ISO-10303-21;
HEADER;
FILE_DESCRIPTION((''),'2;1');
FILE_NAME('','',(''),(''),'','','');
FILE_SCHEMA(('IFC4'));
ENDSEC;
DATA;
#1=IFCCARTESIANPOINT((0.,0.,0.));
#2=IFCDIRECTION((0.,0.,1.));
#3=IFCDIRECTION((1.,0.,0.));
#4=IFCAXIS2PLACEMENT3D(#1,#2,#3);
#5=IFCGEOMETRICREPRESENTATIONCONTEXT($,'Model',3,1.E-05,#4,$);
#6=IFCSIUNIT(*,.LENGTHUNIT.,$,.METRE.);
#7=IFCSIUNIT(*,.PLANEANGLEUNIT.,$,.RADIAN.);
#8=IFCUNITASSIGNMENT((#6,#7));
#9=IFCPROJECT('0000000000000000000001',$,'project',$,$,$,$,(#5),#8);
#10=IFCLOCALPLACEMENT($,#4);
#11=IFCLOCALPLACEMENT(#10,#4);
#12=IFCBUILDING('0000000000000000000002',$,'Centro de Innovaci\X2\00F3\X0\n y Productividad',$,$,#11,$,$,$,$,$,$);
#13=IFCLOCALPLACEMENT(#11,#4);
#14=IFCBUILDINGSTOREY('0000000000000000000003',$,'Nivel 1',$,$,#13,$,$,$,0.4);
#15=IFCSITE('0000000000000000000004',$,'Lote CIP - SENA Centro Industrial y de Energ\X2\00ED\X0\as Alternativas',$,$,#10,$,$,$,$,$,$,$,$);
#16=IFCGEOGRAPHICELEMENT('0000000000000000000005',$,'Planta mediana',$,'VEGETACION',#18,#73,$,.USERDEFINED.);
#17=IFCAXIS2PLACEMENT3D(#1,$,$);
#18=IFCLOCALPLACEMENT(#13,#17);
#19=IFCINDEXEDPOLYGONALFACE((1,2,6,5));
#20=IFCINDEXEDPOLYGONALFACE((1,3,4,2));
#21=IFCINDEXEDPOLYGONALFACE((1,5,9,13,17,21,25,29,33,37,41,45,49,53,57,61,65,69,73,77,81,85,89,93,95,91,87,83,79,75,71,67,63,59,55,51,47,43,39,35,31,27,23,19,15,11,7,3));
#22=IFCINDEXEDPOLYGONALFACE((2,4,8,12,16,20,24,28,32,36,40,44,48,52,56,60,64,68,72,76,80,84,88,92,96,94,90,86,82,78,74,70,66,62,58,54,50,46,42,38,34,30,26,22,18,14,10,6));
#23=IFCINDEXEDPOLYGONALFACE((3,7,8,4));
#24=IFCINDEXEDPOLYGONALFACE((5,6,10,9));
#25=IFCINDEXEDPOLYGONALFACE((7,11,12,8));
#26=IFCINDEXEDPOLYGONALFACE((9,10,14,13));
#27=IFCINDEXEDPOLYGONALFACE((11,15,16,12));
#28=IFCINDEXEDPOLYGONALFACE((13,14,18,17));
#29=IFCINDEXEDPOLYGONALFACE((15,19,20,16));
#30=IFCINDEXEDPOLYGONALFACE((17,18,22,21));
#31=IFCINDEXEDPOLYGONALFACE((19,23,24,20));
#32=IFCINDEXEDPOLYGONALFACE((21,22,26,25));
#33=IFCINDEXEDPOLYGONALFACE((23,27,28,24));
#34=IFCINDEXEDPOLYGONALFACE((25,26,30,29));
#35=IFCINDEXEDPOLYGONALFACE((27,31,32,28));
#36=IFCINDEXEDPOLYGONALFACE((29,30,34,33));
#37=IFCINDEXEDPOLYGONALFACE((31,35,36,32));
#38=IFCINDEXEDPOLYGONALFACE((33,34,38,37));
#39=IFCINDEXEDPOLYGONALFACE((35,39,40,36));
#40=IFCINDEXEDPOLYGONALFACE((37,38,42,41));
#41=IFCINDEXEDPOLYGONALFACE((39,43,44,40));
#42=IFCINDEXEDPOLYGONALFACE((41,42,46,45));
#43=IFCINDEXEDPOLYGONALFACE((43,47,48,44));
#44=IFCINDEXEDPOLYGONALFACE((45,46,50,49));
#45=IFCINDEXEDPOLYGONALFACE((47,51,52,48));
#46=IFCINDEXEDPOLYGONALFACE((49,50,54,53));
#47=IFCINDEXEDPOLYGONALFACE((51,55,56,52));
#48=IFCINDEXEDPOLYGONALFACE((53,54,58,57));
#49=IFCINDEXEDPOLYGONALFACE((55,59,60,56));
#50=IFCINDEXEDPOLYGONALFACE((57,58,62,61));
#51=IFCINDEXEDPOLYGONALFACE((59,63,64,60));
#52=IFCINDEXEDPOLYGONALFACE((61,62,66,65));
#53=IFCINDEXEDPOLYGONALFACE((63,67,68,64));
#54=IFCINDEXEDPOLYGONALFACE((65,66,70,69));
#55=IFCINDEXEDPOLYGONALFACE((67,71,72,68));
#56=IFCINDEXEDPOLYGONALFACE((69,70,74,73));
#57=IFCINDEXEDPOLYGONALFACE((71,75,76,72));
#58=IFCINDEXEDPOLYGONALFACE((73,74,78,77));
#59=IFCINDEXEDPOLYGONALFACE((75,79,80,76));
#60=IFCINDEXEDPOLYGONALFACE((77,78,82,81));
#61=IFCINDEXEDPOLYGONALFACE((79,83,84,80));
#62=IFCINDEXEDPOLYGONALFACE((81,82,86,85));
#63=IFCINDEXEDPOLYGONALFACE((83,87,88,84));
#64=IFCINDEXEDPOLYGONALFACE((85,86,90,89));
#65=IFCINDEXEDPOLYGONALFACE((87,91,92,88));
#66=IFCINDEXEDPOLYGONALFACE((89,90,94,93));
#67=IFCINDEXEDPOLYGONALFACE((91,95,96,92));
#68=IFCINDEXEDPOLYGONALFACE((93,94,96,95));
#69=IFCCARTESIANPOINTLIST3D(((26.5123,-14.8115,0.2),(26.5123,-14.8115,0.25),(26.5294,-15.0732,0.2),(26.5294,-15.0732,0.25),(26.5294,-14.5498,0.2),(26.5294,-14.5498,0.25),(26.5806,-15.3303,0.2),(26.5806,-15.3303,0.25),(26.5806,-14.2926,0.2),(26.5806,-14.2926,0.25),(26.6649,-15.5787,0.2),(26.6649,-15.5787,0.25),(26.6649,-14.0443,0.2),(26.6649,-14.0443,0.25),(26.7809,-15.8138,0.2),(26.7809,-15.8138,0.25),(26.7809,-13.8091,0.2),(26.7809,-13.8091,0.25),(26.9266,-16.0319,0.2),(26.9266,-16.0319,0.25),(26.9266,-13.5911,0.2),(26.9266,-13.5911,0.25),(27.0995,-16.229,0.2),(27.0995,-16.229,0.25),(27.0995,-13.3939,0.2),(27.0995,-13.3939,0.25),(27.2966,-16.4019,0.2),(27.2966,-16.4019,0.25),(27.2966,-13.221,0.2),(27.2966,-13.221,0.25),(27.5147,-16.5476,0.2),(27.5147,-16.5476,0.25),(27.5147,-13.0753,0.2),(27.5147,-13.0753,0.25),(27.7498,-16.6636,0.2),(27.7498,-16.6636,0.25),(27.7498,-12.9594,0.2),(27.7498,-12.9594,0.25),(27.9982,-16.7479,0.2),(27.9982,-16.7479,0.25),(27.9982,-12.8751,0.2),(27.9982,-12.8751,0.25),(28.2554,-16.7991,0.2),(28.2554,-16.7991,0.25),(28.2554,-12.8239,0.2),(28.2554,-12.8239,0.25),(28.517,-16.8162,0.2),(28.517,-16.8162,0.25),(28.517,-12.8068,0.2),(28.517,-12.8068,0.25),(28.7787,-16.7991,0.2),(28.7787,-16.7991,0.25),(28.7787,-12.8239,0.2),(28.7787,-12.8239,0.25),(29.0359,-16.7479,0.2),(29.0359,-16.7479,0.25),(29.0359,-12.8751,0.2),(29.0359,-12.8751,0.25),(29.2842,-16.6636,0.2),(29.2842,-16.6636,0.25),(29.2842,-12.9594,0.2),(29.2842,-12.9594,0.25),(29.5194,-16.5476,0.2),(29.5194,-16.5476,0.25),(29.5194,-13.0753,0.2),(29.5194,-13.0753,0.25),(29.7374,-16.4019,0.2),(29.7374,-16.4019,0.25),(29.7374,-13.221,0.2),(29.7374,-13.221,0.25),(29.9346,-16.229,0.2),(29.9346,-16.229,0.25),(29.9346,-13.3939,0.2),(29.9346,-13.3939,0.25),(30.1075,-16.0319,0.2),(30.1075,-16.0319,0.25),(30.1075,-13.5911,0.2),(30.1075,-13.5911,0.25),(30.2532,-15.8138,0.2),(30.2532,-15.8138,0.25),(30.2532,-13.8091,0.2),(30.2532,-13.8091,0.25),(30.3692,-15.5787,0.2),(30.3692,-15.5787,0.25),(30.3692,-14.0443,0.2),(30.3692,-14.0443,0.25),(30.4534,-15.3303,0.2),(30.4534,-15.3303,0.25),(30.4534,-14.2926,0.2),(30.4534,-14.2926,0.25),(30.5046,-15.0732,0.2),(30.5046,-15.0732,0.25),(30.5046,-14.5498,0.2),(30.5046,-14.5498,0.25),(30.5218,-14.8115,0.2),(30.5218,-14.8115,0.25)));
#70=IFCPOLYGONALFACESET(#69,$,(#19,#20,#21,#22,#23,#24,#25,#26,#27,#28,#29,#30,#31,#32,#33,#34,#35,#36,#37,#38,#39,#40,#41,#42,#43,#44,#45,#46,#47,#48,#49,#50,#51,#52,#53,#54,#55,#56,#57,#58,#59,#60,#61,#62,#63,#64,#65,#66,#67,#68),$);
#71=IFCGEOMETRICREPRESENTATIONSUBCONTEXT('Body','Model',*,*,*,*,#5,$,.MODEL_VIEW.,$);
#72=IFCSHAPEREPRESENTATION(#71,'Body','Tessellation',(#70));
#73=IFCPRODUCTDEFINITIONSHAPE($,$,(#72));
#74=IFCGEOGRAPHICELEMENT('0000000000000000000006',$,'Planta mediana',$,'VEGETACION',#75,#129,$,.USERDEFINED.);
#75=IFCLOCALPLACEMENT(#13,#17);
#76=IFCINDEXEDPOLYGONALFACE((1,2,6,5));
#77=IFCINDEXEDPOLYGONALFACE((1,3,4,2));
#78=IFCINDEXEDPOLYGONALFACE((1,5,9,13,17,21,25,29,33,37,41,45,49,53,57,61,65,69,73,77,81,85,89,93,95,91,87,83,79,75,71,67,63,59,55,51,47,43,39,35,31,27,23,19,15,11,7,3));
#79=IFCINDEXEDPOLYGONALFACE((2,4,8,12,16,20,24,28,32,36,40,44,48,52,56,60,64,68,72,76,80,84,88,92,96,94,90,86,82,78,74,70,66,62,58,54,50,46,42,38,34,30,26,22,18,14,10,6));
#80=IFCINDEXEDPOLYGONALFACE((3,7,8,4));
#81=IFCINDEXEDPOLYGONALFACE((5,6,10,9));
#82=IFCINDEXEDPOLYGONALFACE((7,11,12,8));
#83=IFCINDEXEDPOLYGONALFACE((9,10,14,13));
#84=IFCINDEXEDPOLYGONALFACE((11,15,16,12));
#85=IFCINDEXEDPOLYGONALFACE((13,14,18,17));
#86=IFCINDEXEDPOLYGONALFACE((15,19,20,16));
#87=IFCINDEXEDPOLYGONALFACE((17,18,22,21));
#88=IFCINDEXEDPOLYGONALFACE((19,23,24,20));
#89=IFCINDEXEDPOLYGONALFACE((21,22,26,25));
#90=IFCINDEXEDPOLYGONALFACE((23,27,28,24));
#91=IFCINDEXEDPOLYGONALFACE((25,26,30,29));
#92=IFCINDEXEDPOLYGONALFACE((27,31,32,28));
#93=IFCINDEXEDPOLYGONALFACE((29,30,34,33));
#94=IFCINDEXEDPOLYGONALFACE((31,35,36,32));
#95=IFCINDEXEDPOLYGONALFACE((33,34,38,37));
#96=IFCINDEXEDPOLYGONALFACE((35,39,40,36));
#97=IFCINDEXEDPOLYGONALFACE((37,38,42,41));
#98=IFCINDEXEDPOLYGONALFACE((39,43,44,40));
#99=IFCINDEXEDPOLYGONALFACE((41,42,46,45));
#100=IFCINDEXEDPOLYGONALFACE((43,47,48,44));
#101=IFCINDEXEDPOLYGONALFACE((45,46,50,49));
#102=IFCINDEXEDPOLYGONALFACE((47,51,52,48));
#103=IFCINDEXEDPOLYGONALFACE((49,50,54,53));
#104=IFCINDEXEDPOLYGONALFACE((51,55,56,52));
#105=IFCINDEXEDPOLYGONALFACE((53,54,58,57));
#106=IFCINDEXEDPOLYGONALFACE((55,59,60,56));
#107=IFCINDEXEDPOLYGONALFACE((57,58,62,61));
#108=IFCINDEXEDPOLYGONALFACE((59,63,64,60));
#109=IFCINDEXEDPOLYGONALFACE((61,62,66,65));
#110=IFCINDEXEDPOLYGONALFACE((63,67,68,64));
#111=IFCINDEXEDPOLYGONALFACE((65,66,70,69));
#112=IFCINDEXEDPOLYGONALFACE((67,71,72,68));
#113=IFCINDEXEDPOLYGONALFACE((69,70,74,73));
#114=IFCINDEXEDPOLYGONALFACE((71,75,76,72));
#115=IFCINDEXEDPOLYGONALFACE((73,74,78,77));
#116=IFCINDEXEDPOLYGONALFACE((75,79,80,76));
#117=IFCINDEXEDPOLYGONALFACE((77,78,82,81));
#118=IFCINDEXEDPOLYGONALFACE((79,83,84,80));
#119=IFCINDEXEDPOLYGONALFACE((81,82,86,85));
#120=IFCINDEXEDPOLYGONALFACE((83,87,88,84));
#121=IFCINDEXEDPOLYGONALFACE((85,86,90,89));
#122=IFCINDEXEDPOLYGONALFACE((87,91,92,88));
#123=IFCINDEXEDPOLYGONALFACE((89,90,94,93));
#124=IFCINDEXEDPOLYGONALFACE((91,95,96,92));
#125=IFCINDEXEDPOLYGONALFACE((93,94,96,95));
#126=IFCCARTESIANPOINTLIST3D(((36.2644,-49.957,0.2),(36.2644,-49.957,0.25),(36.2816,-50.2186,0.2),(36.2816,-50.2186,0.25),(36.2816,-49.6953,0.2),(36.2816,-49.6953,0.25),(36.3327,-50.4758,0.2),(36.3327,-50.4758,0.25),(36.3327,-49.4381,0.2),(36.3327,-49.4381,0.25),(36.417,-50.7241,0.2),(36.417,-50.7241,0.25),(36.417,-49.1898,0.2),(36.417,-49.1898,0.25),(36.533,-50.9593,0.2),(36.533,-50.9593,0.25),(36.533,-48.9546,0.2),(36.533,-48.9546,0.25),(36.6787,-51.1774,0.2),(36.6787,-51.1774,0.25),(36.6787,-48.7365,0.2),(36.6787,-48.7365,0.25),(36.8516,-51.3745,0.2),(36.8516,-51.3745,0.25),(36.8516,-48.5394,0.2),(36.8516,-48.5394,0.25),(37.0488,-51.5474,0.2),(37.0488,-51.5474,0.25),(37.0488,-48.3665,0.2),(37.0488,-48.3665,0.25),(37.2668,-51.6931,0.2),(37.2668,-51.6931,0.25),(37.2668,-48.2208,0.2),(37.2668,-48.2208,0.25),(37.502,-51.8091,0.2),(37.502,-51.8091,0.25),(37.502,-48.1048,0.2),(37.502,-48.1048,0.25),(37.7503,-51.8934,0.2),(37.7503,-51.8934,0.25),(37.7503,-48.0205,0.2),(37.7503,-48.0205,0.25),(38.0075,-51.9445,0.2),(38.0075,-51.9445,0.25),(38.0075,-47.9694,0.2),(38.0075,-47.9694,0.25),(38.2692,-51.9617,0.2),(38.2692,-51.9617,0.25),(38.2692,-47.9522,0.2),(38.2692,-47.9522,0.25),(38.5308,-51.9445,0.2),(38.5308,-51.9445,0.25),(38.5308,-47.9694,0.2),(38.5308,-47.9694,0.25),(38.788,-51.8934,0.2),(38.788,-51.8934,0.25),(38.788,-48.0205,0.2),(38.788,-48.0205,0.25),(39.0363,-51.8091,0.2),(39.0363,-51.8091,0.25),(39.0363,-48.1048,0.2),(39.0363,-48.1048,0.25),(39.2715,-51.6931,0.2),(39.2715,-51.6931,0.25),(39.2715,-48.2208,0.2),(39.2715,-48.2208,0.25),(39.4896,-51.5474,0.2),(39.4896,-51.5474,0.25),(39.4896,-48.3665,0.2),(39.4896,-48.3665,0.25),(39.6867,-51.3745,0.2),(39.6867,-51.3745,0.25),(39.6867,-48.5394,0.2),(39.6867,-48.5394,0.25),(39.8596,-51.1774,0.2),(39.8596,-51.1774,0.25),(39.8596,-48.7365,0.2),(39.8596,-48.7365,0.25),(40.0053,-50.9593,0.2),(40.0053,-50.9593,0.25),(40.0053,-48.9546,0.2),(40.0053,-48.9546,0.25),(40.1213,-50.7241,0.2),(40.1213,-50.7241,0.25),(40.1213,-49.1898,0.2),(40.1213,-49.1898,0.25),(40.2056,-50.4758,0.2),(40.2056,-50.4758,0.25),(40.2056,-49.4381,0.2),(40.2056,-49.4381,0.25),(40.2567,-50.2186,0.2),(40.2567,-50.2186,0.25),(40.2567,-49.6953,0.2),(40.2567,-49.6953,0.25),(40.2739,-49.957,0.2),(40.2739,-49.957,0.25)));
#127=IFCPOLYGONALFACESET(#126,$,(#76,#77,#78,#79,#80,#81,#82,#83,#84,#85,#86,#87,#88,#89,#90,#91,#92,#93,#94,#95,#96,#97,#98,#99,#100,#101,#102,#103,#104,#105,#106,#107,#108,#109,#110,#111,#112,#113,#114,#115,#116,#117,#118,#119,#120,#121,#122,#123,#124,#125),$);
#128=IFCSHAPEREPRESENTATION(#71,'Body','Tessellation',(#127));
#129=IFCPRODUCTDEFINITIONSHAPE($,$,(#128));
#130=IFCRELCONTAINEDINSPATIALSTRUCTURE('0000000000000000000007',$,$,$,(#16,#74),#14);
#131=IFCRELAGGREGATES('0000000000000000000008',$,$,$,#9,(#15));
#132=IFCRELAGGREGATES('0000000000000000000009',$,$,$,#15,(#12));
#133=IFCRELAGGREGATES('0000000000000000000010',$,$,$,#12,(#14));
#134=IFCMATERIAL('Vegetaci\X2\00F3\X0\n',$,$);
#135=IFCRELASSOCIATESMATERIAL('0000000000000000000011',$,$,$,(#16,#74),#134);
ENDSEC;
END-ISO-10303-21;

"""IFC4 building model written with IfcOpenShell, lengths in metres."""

from ifc_helpers import new_model, si_unit, frame, origin_with_axes, place, context, subcontext, project, spatial, polyline, outline, extrude, material, element, save


model = new_model("IFC4")

# Units and contexts
model_context = context("Model", 3, precision=1e-05, world=origin_with_axes())
body_context = subcontext(model_context, "Body", "Model", "MODEL_VIEW")
ifc_project = project(units=[si_unit("LENGTHUNIT", "METRE"), si_unit("PLANEANGLEUNIT", "RADIAN")], contexts=[model_context])

# Site, building, storey
site_placement = place(None, origin_with_axes())
site = spatial("IfcSite", under=ifc_project, at=site_placement, Name="Lote CIP - SENA Centro Industrial y de Energías Alternativas")
building_placement = place(site_placement, origin_with_axes())
building = spatial("IfcBuilding", under=site, at=building_placement, Name="Centro de Innovación y Productividad")
storey_placement = place(building_placement, origin_with_axes())
storey = spatial("IfcBuildingStorey", under=building, at=storey_placement, Name="Nivel 1", Elevation=0.4)

# Geographic elements
ifc_material_1 = material(Name="Vegetación")
geographic_element_1_placement = place(storey_placement, origin_with_axes())
element("IfcGeographicElement", 1, at=geographic_element_1_placement, inside=storey, material=ifc_material_1, Name="Planta mediana", ObjectType="VEGETACION", PredefinedType="USERDEFINED", context=body_context, shape_type="SweptSolid", body=[
    extrude(outline(polyline([(30.5218, -14.8115), (30.5046, -15.0732), (30.4534, -15.3303), (30.3692, -15.5787), (30.2532, -15.8138), (30.1075, -16.0319), (29.9346, -16.229), (29.7374, -16.4019), (29.5194, -16.5476), (29.2842, -16.6636), (29.0359, -16.7479), (28.7787, -16.7991), (28.517, -16.8162), (28.2554, -16.7991), (27.9982, -16.7479), (27.7498, -16.6636), (27.5147, -16.5476), (27.2966, -16.4019), (27.0995, -16.229), (26.9266, -16.0319), (26.7809, -15.8138), (26.6649, -15.5787), (26.5806, -15.3303), (26.5294, -15.0732), (26.5123, -14.8115), (26.5294, -14.5498), (26.5806, -14.2926), (26.6649, -14.0443), (26.7809, -13.8091), (26.9266, -13.5911), (27.0995, -13.3939), (27.2966, -13.221), (27.5147, -13.0753), (27.7498, -12.9594), (27.9982, -12.8751), (28.2554, -12.8239), (28.517, -12.8068), (28.7787, -12.8239), (29.0359, -12.8751), (29.2842, -12.9594), (29.5194, -13.0753), (29.7374, -13.221), (29.9346, -13.3939), (30.1075, -13.5911), (30.2532, -13.8091), (30.3692, -14.0443), (30.4534, -14.2926), (30.5046, -14.5498), (30.5218, -14.8115)])), frame((0.0, 0.0, 0.2)), (0.0, 0.0, 1.0), 0.05),
])
geographic_element_2_placement = place(storey_placement, origin_with_axes())
element("IfcGeographicElement", 2, at=geographic_element_2_placement, inside=storey, material=ifc_material_1, Name="Planta mediana", ObjectType="VEGETACION", PredefinedType="USERDEFINED", context=body_context, shape_type="SweptSolid", body=[
    extrude(outline(polyline([(40.2739, -49.957), (40.2567, -50.2186), (40.2056, -50.4758), (40.1213, -50.7241), (40.0053, -50.9593), (39.8596, -51.1774), (39.6867, -51.3745), (39.4896, -51.5474), (39.2715, -51.6931), (39.0363, -51.8091), (38.788, -51.8934), (38.5308, -51.9445), (38.2692, -51.9617), (38.0075, -51.9445), (37.7503, -51.8934), (37.502, -51.8091), (37.2668, -51.6931), (37.0488, -51.5474), (36.8516, -51.3745), (36.6787, -51.1774), (36.533, -50.9593), (36.417, -50.7241), (36.3327, -50.4758), (36.2816, -50.2186), (36.2644, -49.957), (36.2816, -49.6953), (36.3327, -49.4381), (36.417, -49.1898), (36.533, -48.9546), (36.6787, -48.7365), (36.8516, -48.5394), (37.0488, -48.3665), (37.2668, -48.2208), (37.502, -48.1048), (37.7503, -48.0205), (38.0075, -47.9694), (38.2692, -47.9522), (38.5308, -47.9694), (38.788, -48.0205), (39.0363, -48.1048), (39.2715, -48.2208), (39.4896, -48.3665), (39.6867, -48.5394), (39.8596, -48.7365), (40.0053, -48.9546), (40.1213, -49.1898), (40.2056, -49.4381), (40.2567, -49.6953), (40.2739, -49.957)])), frame((0.0, 0.0, 0.2)), (0.0, 0.0, 1.0), 0.05),
])

save(model, "model.ifc")
